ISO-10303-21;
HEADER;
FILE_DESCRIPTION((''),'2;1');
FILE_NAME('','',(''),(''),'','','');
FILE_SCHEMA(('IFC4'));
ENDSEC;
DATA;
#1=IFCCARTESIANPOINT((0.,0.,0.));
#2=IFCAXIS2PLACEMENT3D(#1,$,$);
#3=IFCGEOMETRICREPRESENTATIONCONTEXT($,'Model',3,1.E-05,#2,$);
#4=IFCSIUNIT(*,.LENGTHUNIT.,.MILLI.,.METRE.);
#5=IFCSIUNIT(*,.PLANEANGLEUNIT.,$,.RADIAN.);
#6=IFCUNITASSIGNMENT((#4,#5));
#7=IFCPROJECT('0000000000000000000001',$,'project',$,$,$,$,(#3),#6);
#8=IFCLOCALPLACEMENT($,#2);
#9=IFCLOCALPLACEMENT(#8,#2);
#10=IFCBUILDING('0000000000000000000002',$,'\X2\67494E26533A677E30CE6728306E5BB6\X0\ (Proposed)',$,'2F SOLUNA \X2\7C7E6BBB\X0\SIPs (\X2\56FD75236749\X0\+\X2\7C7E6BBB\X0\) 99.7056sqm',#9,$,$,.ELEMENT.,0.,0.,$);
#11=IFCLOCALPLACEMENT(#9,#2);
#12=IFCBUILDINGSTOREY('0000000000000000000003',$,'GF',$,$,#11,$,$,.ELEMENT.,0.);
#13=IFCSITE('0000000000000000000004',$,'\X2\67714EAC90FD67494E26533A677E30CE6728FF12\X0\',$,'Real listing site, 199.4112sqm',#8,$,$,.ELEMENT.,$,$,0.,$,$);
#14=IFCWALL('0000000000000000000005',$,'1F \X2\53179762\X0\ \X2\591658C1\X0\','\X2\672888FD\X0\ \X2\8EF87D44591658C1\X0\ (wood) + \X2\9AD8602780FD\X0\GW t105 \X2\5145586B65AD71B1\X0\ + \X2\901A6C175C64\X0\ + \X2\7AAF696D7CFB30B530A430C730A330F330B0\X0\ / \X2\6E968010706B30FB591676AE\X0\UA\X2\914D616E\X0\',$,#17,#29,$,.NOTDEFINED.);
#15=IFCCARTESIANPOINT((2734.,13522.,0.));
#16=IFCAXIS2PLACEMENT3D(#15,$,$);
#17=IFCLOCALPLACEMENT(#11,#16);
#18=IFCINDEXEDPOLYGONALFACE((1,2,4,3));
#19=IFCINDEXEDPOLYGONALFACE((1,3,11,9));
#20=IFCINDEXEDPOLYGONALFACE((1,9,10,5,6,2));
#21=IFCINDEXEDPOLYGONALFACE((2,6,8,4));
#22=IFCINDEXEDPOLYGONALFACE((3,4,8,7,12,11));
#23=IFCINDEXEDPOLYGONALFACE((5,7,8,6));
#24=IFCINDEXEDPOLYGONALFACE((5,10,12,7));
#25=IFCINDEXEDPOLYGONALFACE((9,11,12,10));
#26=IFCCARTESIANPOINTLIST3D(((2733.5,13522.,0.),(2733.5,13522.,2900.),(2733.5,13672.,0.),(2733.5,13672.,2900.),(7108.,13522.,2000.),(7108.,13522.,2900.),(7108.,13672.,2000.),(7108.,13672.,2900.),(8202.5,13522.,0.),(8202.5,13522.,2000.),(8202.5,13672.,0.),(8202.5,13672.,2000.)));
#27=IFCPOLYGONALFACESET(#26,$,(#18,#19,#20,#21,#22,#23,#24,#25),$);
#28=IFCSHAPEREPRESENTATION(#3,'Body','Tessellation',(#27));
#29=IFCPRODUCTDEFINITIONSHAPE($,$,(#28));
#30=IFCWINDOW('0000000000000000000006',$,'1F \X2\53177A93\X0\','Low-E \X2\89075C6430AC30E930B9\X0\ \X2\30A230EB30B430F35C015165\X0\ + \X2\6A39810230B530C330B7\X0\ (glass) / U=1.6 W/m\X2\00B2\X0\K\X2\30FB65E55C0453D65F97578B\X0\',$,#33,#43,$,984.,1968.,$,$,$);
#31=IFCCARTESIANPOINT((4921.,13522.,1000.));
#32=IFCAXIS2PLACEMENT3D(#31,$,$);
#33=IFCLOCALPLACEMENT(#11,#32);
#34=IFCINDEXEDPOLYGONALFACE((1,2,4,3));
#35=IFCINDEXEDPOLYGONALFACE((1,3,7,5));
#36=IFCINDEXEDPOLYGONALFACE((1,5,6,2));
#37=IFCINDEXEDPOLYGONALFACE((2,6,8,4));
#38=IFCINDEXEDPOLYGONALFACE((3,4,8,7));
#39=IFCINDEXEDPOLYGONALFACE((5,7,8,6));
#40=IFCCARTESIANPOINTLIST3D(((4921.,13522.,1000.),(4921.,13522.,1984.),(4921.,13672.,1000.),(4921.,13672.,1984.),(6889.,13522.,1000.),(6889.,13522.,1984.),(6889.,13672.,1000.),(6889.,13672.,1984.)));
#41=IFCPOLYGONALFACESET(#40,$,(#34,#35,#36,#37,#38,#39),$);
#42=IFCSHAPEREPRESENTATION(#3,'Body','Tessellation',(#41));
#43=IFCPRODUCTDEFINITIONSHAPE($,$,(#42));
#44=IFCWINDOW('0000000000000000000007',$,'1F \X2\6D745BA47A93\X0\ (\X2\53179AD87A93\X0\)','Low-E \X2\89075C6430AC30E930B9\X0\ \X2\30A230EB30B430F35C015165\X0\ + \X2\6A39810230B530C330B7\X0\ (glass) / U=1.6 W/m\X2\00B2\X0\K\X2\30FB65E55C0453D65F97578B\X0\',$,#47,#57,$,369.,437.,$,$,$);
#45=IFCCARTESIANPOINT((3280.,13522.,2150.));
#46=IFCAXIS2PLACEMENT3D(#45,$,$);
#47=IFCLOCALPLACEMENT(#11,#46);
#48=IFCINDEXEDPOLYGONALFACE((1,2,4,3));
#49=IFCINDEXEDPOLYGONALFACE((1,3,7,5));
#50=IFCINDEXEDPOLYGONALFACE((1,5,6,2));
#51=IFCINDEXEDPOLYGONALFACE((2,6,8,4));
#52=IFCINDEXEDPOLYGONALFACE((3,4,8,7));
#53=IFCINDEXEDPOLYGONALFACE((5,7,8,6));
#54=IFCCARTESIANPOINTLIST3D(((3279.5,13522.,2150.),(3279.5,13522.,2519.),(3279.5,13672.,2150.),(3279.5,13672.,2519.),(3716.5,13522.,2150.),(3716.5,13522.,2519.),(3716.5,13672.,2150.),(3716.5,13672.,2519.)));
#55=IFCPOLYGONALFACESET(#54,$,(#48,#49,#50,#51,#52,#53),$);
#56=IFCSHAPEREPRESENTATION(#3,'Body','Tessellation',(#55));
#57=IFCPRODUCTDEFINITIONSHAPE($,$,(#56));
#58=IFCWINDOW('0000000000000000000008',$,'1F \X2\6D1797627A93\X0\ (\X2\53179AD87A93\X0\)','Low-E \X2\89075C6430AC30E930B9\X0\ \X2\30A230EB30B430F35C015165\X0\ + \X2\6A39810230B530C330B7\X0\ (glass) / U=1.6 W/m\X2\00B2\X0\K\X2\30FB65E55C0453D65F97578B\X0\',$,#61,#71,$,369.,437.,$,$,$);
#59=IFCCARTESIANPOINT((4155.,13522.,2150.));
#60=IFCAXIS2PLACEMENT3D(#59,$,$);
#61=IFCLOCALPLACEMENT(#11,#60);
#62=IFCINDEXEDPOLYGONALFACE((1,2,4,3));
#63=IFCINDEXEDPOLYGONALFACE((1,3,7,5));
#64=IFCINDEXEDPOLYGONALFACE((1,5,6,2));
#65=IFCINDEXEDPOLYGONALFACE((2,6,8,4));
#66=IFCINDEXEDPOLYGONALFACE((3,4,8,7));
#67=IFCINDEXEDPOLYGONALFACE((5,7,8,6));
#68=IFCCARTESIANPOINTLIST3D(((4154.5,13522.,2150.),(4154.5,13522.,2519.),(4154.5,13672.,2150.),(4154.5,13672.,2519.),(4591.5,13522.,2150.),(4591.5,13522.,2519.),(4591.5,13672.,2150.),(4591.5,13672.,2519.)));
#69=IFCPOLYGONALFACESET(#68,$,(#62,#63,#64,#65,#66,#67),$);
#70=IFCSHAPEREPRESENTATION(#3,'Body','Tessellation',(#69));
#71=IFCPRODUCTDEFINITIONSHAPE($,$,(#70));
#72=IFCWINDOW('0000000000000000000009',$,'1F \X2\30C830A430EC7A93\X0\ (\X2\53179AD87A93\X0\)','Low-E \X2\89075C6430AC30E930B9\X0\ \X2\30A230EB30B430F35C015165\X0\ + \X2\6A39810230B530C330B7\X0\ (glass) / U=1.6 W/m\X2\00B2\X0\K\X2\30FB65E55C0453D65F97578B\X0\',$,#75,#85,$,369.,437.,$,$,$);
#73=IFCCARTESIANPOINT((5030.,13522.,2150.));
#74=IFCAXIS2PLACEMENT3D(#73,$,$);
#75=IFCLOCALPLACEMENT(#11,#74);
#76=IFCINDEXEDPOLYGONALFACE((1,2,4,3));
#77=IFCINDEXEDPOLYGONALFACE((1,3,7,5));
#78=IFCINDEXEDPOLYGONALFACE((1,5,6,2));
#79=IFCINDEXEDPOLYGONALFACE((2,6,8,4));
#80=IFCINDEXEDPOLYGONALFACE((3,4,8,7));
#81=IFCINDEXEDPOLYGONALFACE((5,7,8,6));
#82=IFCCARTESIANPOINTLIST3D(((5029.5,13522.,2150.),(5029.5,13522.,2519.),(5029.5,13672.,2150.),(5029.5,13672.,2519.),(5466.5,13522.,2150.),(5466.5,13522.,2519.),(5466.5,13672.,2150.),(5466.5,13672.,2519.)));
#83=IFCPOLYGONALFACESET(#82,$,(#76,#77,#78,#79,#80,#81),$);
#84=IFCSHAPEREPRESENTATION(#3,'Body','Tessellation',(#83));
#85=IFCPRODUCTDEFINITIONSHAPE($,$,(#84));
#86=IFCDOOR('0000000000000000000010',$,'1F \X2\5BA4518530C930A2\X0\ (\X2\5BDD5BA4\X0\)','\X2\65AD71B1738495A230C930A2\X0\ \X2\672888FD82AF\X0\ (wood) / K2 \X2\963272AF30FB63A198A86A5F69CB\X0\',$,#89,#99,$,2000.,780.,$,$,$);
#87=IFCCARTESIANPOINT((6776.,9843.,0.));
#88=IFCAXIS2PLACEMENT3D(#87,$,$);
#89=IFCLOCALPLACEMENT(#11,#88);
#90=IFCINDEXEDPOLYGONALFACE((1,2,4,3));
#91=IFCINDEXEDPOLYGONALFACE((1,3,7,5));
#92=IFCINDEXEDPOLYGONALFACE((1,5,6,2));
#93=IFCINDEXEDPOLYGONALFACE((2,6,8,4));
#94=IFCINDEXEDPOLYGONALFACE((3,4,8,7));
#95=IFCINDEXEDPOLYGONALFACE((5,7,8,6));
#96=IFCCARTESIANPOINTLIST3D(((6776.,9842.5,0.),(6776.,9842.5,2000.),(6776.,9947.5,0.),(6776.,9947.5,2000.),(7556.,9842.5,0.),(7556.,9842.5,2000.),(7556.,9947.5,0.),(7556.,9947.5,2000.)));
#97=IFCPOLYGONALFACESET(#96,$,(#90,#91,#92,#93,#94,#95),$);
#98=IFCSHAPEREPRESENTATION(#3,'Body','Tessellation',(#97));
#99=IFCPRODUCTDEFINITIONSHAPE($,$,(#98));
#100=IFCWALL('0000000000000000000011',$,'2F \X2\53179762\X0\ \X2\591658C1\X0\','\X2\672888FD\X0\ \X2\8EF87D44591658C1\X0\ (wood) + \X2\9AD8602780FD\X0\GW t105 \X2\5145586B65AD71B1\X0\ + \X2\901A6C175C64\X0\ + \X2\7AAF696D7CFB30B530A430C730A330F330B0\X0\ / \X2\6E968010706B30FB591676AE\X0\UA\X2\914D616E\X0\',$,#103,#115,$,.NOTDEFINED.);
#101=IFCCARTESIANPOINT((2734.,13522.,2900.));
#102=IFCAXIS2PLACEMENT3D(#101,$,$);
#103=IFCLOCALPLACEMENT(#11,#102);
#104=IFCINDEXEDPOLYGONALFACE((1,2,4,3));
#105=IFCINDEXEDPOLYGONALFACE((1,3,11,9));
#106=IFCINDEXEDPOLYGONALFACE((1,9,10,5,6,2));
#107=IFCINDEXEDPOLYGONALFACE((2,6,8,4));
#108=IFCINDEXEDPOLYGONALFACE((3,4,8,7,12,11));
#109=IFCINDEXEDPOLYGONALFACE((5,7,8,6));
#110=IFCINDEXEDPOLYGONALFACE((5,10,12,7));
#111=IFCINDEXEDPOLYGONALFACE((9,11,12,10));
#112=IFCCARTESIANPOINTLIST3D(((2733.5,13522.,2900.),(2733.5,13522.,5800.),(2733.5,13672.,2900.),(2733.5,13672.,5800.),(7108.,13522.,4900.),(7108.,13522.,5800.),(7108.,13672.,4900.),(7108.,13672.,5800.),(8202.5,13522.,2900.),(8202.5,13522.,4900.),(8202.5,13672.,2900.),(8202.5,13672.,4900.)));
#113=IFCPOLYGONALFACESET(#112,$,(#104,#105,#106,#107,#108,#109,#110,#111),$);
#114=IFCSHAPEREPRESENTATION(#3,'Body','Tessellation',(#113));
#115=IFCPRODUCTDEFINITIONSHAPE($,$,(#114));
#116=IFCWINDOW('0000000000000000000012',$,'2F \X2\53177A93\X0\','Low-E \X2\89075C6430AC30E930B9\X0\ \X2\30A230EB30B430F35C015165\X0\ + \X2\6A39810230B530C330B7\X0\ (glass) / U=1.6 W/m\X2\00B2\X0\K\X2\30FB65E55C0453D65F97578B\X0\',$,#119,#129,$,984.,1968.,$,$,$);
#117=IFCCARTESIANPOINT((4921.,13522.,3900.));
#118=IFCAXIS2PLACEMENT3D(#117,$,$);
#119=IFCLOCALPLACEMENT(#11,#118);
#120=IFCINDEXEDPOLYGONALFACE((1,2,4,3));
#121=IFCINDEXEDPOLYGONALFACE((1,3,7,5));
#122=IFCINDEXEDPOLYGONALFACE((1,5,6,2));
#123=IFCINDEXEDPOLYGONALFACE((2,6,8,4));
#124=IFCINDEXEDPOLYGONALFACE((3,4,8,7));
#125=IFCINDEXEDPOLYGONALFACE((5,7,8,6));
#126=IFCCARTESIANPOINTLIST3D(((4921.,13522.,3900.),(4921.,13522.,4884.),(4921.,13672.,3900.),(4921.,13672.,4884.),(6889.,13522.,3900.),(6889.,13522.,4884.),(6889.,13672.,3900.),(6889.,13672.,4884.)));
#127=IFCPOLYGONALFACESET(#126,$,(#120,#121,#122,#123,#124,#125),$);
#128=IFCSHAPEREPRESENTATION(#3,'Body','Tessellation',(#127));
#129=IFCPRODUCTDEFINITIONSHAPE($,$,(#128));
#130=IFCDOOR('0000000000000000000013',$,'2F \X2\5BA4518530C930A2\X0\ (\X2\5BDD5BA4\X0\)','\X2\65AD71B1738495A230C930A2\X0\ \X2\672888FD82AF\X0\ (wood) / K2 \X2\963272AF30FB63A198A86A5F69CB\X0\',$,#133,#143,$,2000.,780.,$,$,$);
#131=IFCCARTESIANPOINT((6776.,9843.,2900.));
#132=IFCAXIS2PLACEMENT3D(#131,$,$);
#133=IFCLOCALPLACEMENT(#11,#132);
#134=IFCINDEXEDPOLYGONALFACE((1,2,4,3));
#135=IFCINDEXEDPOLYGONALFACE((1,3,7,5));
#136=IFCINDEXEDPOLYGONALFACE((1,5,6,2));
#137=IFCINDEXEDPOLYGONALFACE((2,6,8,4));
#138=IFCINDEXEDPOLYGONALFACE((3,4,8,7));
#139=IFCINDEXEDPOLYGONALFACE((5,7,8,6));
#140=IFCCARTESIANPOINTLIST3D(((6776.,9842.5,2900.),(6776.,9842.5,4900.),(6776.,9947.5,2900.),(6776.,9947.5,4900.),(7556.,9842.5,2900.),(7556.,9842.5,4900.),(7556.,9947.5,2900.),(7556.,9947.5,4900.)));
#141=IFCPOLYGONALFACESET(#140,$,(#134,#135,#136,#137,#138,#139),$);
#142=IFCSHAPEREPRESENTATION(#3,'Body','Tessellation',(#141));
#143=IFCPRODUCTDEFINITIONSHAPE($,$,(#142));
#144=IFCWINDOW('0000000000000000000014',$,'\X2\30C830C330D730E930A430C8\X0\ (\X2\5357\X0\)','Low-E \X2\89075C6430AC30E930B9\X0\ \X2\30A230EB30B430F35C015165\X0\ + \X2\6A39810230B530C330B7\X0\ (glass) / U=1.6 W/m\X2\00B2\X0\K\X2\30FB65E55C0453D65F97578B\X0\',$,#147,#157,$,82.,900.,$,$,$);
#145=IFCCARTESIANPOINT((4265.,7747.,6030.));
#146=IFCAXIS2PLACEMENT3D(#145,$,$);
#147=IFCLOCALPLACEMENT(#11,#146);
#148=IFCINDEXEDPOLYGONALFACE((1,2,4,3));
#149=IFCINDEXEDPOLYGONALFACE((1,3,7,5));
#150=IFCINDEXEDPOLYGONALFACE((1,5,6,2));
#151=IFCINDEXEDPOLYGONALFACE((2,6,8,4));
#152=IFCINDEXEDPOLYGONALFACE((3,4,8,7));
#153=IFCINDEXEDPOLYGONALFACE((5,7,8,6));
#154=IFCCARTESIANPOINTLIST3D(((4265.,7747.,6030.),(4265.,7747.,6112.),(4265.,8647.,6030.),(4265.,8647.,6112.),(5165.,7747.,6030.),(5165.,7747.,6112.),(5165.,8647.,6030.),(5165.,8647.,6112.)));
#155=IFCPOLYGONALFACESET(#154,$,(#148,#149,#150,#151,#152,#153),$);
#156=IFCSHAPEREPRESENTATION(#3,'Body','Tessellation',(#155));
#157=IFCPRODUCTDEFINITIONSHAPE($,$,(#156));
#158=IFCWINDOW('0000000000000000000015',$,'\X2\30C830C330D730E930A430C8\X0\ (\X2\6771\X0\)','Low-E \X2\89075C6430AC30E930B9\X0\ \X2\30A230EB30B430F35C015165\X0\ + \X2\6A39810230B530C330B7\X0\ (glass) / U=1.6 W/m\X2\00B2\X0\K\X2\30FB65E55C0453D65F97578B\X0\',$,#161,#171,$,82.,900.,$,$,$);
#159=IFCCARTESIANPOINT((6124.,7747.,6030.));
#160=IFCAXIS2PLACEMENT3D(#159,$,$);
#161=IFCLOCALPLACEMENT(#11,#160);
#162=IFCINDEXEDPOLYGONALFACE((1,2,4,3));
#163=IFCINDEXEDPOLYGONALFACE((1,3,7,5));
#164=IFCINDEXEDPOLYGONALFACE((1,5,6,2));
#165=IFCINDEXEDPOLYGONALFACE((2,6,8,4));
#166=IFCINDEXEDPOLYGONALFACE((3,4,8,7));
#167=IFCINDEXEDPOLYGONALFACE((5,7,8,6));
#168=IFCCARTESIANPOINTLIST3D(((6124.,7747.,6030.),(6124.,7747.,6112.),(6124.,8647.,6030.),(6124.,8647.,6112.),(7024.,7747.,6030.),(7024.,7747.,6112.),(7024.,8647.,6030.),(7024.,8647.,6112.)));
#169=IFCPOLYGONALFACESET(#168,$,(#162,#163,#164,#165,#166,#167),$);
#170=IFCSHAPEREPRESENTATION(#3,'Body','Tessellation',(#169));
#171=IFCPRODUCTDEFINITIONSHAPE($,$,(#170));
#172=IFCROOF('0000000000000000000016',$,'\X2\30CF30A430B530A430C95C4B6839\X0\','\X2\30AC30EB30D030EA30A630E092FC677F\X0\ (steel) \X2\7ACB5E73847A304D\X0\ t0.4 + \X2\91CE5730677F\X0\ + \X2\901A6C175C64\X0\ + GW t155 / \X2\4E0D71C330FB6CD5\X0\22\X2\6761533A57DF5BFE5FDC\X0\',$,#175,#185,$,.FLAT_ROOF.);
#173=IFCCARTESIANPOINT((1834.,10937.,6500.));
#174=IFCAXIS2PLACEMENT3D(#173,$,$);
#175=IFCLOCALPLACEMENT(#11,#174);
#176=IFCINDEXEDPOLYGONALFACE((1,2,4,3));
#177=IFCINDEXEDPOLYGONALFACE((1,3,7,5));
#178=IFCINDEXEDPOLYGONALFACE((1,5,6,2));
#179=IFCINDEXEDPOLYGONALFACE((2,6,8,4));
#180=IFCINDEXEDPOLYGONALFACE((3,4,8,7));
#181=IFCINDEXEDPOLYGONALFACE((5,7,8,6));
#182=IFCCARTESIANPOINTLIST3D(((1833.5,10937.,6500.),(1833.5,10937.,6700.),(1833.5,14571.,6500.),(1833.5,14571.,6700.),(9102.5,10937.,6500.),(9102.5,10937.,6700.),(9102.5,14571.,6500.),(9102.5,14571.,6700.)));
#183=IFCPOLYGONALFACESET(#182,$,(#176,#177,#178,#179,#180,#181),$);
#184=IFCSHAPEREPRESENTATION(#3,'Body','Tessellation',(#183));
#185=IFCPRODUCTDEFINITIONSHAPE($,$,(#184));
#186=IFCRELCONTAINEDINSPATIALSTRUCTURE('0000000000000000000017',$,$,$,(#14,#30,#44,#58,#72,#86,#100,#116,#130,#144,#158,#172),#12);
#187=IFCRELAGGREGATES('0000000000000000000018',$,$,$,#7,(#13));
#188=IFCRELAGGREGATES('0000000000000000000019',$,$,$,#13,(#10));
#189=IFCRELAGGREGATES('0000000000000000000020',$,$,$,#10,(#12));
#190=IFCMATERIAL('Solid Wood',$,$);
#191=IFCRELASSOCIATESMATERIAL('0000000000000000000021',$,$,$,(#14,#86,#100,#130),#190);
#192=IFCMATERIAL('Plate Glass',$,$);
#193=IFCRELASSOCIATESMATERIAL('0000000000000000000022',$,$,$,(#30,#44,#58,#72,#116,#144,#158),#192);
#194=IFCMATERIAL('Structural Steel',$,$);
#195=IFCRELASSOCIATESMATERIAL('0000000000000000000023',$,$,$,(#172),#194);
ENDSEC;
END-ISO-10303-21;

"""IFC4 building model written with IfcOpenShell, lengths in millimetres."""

from ifc_helpers import new_model, si_unit, frame, frame_2d, origin, place, context, project, spatial, rectangle, extrude, material, element, fill, save


model = new_model("IFC4")

# Units and contexts
model_context = context("Model", 3, precision=1e-05, world=origin())
ifc_project = project(units=[si_unit("LENGTHUNIT", "METRE", prefix="MILLI"), si_unit("PLANEANGLEUNIT", "RADIAN")], contexts=[model_context])

# Site, building, storey
site_placement = place(None, origin())
site = spatial("IfcSite", under=ifc_project, at=site_placement, Name="東京都杉並区松ノ木２", ObjectType="Real listing site, 199.4112sqm", CompositionType="ELEMENT", RefElevation=0.0)
building_placement = place(site_placement, origin())
building = spatial("IfcBuilding", under=site, at=building_placement, Name="杉並区松ノ木の家 (Proposed)", ObjectType="2F SOLUNA 籾殻SIPs (国産杉+籾殻) 99.7056sqm", CompositionType="ELEMENT", ElevationOfRefHeight=0.0, ElevationOfTerrain=0.0)
storey_placement = place(building_placement, origin())
storey = spatial("IfcBuildingStorey", under=building, at=storey_placement, Name="GF", CompositionType="ELEMENT", Elevation=0.0)

# Wall, openings, windows
ifc_material_1 = material(Name="Solid Wood")
wall_1_placement = place(storey_placement, frame((2734.0, 13522.0, 0.0)))
wall_1 = element("IfcWall", 1, at=wall_1_placement, inside=storey, material=ifc_material_1, Name="1F 北面 外壁", Description="木製 軸組外壁 (wood) + 高性能GW t105 充填断熱 + 通気層 + 窯業系サイディング / 準耐火・外皮UA配慮", PredefinedType="NOTDEFINED", context=model_context, shape_type="SweptSolid", body=[
    extrude(rectangle(XDim=5469.0, YDim=150.0, at=frame_2d((2734.0, 75.0))), frame((2734.0, 13522.0, 0.0)), (0.0, 0.0, 1.0), 2900.0),
])
opening_1_placement = place(storey_placement, frame((4921.0, 13522.0, 1000.0)))
opening_1 = element("IfcOpeningElement", 2, at=opening_1_placement, cuts=wall_1, PredefinedType="NOTDEFINED", context=model_context, shape_type="SweptSolid", body=[
    extrude(rectangle(XDim=1968.0, YDim=150.0, at=frame_2d((984.0, 75.0))), frame((4921.0, 13522.0, 1000.0)), (0.0, 0.0, 1.0), 984.0),
])
opening_2_placement = place(storey_placement, frame((3280.0, 13522.0, 2150.0)))
opening_2 = element("IfcOpeningElement", 3, at=opening_2_placement, cuts=wall_1, PredefinedType="NOTDEFINED", context=model_context, shape_type="SweptSolid", body=[
    extrude(rectangle(XDim=437.0, YDim=150.0, at=frame_2d((218.0, 75.0))), frame((3280.0, 13522.0, 2150.0)), (0.0, 0.0, 1.0), 369.0),
])
opening_3_placement = place(storey_placement, frame((4155.0, 13522.0, 2150.0)))
opening_3 = element("IfcOpeningElement", 4, at=opening_3_placement, cuts=wall_1, PredefinedType="NOTDEFINED", context=model_context, shape_type="SweptSolid", body=[
    extrude(rectangle(XDim=437.0, YDim=150.0, at=frame_2d((218.0, 75.0))), frame((4155.0, 13522.0, 2150.0)), (0.0, 0.0, 1.0), 369.0),
])
opening_4_placement = place(storey_placement, frame((5030.0, 13522.0, 2150.0)))
opening_4 = element("IfcOpeningElement", 5, at=opening_4_placement, cuts=wall_1, PredefinedType="NOTDEFINED", context=model_context, shape_type="SweptSolid", body=[
    extrude(rectangle(XDim=437.0, YDim=150.0, at=frame_2d((218.0, 75.0))), frame((5030.0, 13522.0, 2150.0)), (0.0, 0.0, 1.0), 369.0),
])
ifc_material_2 = material(Name="Plate Glass")
window_1_placement = place(storey_placement, frame((4921.0, 13522.0, 1000.0)))
window_1 = element("IfcWindow", 6, at=window_1_placement, inside=storey, material=ifc_material_2, Name="1F 北窓", Description="Low-E 複層ガラス アルゴン封入 + 樹脂サッシ (glass) / U=1.6 W/m²K・日射取得型", OverallHeight=984.0, OverallWidth=1968.0, context=model_context, shape_type="SweptSolid", body=[
    extrude(rectangle(XDim=1968.0, YDim=150.0, at=frame_2d((984.0, 75.0))), frame((4921.0, 13522.0, 1000.0)), (0.0, 0.0, 1.0), 984.0),
])
fill(opening_1, window_1)
window_2_placement = place(storey_placement, frame((3280.0, 13522.0, 2150.0)))
window_2 = element("IfcWindow", 7, at=window_2_placement, inside=storey, material=ifc_material_2, Name="1F 浴室窓 (北高窓)", Description="Low-E 複層ガラス アルゴン封入 + 樹脂サッシ (glass) / U=1.6 W/m²K・日射取得型", OverallHeight=369.0, OverallWidth=437.0, context=model_context, shape_type="SweptSolid", body=[
    extrude(rectangle(XDim=437.0, YDim=150.0, at=frame_2d((218.0, 75.0))), frame((3280.0, 13522.0, 2150.0)), (0.0, 0.0, 1.0), 369.0),
])
fill(opening_2, window_2)
window_3_placement = place(storey_placement, frame((4155.0, 13522.0, 2150.0)))
window_3 = element("IfcWindow", 8, at=window_3_placement, inside=storey, material=ifc_material_2, Name="1F 洗面窓 (北高窓)", Description="Low-E 複層ガラス アルゴン封入 + 樹脂サッシ (glass) / U=1.6 W/m²K・日射取得型", OverallHeight=369.0, OverallWidth=437.0, context=model_context, shape_type="SweptSolid", body=[
    extrude(rectangle(XDim=437.0, YDim=150.0, at=frame_2d((218.0, 75.0))), frame((4155.0, 13522.0, 2150.0)), (0.0, 0.0, 1.0), 369.0),
])
fill(opening_3, window_3)
window_4_placement = place(storey_placement, frame((5030.0, 13522.0, 2150.0)))
window_4 = element("IfcWindow", 9, at=window_4_placement, inside=storey, material=ifc_material_2, Name="1F トイレ窓 (北高窓)", Description="Low-E 複層ガラス アルゴン封入 + 樹脂サッシ (glass) / U=1.6 W/m²K・日射取得型", OverallHeight=369.0, OverallWidth=437.0, context=model_context, shape_type="SweptSolid", body=[
    extrude(rectangle(XDim=437.0, YDim=150.0, at=frame_2d((218.0, 75.0))), frame((5030.0, 13522.0, 2150.0)), (0.0, 0.0, 1.0), 369.0),
])
fill(opening_4, window_4)

# Door
door_1_placement = place(storey_placement, frame((6776.0, 9843.0, 0.0)))
element("IfcDoor", 10, at=door_1_placement, inside=storey, material=ifc_material_1, Name="1F 室内ドア (寝室)", Description="断熱玄関ドア 木製芯 (wood) / K2 防犯・採風機構", OverallHeight=2000.0, OverallWidth=780.0, context=model_context, shape_type="SweptSolid", body=[
    extrude(rectangle(XDim=780.0, YDim=105.0, at=frame_2d((390.0, 52.0))), frame((6776.0, 9843.0, 0.0)), (0.0, 0.0, 1.0), 2000.0),
])

# Wall, opening, window
wall_2_placement = place(storey_placement, frame((2734.0, 13522.0, 2900.0)))
wall_2 = element("IfcWall", 11, at=wall_2_placement, inside=storey, material=ifc_material_1, Name="2F 北面 外壁", Description="木製 軸組外壁 (wood) + 高性能GW t105 充填断熱 + 通気層 + 窯業系サイディング / 準耐火・外皮UA配慮", PredefinedType="NOTDEFINED", context=model_context, shape_type="SweptSolid", body=[
    extrude(rectangle(XDim=5469.0, YDim=150.0, at=frame_2d((2734.0, 75.0))), frame((2734.0, 13522.0, 2900.0)), (0.0, 0.0, 1.0), 2900.0),
])
opening_5_placement = place(storey_placement, frame((4921.0, 13522.0, 3900.0)))
opening_5 = element("IfcOpeningElement", 12, at=opening_5_placement, cuts=wall_2, PredefinedType="NOTDEFINED", context=model_context, shape_type="SweptSolid", body=[
    extrude(rectangle(XDim=1968.0, YDim=150.0, at=frame_2d((984.0, 75.0))), frame((4921.0, 13522.0, 3900.0)), (0.0, 0.0, 1.0), 984.0),
])
window_5_placement = place(storey_placement, frame((4921.0, 13522.0, 3900.0)))
window_5 = element("IfcWindow", 13, at=window_5_placement, inside=storey, material=ifc_material_2, Name="2F 北窓", Description="Low-E 複層ガラス アルゴン封入 + 樹脂サッシ (glass) / U=1.6 W/m²K・日射取得型", OverallHeight=984.0, OverallWidth=1968.0, context=model_context, shape_type="SweptSolid", body=[
    extrude(rectangle(XDim=1968.0, YDim=150.0, at=frame_2d((984.0, 75.0))), frame((4921.0, 13522.0, 3900.0)), (0.0, 0.0, 1.0), 984.0),
])
fill(opening_5, window_5)

# Door
door_2_placement = place(storey_placement, frame((6776.0, 9843.0, 2900.0)))
element("IfcDoor", 14, at=door_2_placement, inside=storey, material=ifc_material_1, Name="2F 室内ドア (寝室)", Description="断熱玄関ドア 木製芯 (wood) / K2 防犯・採風機構", OverallHeight=2000.0, OverallWidth=780.0, context=model_context, shape_type="SweptSolid", body=[
    extrude(rectangle(XDim=780.0, YDim=105.0, at=frame_2d((390.0, 52.0))), frame((6776.0, 9843.0, 2900.0)), (0.0, 0.0, 1.0), 2000.0),
])

# Windows
window_6_placement = place(storey_placement, frame((4265.0, 7747.0, 6030.0)))
element("IfcWindow", 15, at=window_6_placement, inside=storey, material=ifc_material_2, Name="トップライト (南)", Description="Low-E 複層ガラス アルゴン封入 + 樹脂サッシ (glass) / U=1.6 W/m²K・日射取得型", OverallHeight=82.0, OverallWidth=900.0, context=model_context, shape_type="SweptSolid", body=[
    extrude(rectangle(XDim=900.0, YDim=900.0, at=frame_2d((450.0, 450.0))), frame((4265.0, 7747.0, 6030.0)), (0.0, 0.0, 1.0), 82.0),
])
window_7_placement = place(storey_placement, frame((6124.0, 7747.0, 6030.0)))
element("IfcWindow", 16, at=window_7_placement, inside=storey, material=ifc_material_2, Name="トップライト (東)", Description="Low-E 複層ガラス アルゴン封入 + 樹脂サッシ (glass) / U=1.6 W/m²K・日射取得型", OverallHeight=82.0, OverallWidth=900.0, context=model_context, shape_type="SweptSolid", body=[
    extrude(rectangle(XDim=900.0, YDim=900.0, at=frame_2d((450.0, 450.0))), frame((6124.0, 7747.0, 6030.0)), (0.0, 0.0, 1.0), 82.0),
])

# Roof
ifc_material_3 = material(Name="Structural Steel")
roof_placement = place(storey_placement, frame((1834.0, 10937.0, 6500.0)))
element("IfcRoof", 17, at=roof_placement, inside=storey, material=ifc_material_3, Name="ハイサイド屋根", Description="ガルバリウム鋼板 (steel) 立平葺き t0.4 + 野地板 + 通気層 + GW t155 / 不燃・法22条区域対応", PredefinedType="FLAT_ROOF", context=model_context, shape_type="SweptSolid", body=[
    extrude(rectangle(XDim=7269.0, YDim=3634.0, at=frame_2d((3634.0, 1817.0))), frame((1834.0, 10937.0, 6500.0)), (0.0, 0.0, 1.0), 200.0),
])

save(model, "model.ifc")
